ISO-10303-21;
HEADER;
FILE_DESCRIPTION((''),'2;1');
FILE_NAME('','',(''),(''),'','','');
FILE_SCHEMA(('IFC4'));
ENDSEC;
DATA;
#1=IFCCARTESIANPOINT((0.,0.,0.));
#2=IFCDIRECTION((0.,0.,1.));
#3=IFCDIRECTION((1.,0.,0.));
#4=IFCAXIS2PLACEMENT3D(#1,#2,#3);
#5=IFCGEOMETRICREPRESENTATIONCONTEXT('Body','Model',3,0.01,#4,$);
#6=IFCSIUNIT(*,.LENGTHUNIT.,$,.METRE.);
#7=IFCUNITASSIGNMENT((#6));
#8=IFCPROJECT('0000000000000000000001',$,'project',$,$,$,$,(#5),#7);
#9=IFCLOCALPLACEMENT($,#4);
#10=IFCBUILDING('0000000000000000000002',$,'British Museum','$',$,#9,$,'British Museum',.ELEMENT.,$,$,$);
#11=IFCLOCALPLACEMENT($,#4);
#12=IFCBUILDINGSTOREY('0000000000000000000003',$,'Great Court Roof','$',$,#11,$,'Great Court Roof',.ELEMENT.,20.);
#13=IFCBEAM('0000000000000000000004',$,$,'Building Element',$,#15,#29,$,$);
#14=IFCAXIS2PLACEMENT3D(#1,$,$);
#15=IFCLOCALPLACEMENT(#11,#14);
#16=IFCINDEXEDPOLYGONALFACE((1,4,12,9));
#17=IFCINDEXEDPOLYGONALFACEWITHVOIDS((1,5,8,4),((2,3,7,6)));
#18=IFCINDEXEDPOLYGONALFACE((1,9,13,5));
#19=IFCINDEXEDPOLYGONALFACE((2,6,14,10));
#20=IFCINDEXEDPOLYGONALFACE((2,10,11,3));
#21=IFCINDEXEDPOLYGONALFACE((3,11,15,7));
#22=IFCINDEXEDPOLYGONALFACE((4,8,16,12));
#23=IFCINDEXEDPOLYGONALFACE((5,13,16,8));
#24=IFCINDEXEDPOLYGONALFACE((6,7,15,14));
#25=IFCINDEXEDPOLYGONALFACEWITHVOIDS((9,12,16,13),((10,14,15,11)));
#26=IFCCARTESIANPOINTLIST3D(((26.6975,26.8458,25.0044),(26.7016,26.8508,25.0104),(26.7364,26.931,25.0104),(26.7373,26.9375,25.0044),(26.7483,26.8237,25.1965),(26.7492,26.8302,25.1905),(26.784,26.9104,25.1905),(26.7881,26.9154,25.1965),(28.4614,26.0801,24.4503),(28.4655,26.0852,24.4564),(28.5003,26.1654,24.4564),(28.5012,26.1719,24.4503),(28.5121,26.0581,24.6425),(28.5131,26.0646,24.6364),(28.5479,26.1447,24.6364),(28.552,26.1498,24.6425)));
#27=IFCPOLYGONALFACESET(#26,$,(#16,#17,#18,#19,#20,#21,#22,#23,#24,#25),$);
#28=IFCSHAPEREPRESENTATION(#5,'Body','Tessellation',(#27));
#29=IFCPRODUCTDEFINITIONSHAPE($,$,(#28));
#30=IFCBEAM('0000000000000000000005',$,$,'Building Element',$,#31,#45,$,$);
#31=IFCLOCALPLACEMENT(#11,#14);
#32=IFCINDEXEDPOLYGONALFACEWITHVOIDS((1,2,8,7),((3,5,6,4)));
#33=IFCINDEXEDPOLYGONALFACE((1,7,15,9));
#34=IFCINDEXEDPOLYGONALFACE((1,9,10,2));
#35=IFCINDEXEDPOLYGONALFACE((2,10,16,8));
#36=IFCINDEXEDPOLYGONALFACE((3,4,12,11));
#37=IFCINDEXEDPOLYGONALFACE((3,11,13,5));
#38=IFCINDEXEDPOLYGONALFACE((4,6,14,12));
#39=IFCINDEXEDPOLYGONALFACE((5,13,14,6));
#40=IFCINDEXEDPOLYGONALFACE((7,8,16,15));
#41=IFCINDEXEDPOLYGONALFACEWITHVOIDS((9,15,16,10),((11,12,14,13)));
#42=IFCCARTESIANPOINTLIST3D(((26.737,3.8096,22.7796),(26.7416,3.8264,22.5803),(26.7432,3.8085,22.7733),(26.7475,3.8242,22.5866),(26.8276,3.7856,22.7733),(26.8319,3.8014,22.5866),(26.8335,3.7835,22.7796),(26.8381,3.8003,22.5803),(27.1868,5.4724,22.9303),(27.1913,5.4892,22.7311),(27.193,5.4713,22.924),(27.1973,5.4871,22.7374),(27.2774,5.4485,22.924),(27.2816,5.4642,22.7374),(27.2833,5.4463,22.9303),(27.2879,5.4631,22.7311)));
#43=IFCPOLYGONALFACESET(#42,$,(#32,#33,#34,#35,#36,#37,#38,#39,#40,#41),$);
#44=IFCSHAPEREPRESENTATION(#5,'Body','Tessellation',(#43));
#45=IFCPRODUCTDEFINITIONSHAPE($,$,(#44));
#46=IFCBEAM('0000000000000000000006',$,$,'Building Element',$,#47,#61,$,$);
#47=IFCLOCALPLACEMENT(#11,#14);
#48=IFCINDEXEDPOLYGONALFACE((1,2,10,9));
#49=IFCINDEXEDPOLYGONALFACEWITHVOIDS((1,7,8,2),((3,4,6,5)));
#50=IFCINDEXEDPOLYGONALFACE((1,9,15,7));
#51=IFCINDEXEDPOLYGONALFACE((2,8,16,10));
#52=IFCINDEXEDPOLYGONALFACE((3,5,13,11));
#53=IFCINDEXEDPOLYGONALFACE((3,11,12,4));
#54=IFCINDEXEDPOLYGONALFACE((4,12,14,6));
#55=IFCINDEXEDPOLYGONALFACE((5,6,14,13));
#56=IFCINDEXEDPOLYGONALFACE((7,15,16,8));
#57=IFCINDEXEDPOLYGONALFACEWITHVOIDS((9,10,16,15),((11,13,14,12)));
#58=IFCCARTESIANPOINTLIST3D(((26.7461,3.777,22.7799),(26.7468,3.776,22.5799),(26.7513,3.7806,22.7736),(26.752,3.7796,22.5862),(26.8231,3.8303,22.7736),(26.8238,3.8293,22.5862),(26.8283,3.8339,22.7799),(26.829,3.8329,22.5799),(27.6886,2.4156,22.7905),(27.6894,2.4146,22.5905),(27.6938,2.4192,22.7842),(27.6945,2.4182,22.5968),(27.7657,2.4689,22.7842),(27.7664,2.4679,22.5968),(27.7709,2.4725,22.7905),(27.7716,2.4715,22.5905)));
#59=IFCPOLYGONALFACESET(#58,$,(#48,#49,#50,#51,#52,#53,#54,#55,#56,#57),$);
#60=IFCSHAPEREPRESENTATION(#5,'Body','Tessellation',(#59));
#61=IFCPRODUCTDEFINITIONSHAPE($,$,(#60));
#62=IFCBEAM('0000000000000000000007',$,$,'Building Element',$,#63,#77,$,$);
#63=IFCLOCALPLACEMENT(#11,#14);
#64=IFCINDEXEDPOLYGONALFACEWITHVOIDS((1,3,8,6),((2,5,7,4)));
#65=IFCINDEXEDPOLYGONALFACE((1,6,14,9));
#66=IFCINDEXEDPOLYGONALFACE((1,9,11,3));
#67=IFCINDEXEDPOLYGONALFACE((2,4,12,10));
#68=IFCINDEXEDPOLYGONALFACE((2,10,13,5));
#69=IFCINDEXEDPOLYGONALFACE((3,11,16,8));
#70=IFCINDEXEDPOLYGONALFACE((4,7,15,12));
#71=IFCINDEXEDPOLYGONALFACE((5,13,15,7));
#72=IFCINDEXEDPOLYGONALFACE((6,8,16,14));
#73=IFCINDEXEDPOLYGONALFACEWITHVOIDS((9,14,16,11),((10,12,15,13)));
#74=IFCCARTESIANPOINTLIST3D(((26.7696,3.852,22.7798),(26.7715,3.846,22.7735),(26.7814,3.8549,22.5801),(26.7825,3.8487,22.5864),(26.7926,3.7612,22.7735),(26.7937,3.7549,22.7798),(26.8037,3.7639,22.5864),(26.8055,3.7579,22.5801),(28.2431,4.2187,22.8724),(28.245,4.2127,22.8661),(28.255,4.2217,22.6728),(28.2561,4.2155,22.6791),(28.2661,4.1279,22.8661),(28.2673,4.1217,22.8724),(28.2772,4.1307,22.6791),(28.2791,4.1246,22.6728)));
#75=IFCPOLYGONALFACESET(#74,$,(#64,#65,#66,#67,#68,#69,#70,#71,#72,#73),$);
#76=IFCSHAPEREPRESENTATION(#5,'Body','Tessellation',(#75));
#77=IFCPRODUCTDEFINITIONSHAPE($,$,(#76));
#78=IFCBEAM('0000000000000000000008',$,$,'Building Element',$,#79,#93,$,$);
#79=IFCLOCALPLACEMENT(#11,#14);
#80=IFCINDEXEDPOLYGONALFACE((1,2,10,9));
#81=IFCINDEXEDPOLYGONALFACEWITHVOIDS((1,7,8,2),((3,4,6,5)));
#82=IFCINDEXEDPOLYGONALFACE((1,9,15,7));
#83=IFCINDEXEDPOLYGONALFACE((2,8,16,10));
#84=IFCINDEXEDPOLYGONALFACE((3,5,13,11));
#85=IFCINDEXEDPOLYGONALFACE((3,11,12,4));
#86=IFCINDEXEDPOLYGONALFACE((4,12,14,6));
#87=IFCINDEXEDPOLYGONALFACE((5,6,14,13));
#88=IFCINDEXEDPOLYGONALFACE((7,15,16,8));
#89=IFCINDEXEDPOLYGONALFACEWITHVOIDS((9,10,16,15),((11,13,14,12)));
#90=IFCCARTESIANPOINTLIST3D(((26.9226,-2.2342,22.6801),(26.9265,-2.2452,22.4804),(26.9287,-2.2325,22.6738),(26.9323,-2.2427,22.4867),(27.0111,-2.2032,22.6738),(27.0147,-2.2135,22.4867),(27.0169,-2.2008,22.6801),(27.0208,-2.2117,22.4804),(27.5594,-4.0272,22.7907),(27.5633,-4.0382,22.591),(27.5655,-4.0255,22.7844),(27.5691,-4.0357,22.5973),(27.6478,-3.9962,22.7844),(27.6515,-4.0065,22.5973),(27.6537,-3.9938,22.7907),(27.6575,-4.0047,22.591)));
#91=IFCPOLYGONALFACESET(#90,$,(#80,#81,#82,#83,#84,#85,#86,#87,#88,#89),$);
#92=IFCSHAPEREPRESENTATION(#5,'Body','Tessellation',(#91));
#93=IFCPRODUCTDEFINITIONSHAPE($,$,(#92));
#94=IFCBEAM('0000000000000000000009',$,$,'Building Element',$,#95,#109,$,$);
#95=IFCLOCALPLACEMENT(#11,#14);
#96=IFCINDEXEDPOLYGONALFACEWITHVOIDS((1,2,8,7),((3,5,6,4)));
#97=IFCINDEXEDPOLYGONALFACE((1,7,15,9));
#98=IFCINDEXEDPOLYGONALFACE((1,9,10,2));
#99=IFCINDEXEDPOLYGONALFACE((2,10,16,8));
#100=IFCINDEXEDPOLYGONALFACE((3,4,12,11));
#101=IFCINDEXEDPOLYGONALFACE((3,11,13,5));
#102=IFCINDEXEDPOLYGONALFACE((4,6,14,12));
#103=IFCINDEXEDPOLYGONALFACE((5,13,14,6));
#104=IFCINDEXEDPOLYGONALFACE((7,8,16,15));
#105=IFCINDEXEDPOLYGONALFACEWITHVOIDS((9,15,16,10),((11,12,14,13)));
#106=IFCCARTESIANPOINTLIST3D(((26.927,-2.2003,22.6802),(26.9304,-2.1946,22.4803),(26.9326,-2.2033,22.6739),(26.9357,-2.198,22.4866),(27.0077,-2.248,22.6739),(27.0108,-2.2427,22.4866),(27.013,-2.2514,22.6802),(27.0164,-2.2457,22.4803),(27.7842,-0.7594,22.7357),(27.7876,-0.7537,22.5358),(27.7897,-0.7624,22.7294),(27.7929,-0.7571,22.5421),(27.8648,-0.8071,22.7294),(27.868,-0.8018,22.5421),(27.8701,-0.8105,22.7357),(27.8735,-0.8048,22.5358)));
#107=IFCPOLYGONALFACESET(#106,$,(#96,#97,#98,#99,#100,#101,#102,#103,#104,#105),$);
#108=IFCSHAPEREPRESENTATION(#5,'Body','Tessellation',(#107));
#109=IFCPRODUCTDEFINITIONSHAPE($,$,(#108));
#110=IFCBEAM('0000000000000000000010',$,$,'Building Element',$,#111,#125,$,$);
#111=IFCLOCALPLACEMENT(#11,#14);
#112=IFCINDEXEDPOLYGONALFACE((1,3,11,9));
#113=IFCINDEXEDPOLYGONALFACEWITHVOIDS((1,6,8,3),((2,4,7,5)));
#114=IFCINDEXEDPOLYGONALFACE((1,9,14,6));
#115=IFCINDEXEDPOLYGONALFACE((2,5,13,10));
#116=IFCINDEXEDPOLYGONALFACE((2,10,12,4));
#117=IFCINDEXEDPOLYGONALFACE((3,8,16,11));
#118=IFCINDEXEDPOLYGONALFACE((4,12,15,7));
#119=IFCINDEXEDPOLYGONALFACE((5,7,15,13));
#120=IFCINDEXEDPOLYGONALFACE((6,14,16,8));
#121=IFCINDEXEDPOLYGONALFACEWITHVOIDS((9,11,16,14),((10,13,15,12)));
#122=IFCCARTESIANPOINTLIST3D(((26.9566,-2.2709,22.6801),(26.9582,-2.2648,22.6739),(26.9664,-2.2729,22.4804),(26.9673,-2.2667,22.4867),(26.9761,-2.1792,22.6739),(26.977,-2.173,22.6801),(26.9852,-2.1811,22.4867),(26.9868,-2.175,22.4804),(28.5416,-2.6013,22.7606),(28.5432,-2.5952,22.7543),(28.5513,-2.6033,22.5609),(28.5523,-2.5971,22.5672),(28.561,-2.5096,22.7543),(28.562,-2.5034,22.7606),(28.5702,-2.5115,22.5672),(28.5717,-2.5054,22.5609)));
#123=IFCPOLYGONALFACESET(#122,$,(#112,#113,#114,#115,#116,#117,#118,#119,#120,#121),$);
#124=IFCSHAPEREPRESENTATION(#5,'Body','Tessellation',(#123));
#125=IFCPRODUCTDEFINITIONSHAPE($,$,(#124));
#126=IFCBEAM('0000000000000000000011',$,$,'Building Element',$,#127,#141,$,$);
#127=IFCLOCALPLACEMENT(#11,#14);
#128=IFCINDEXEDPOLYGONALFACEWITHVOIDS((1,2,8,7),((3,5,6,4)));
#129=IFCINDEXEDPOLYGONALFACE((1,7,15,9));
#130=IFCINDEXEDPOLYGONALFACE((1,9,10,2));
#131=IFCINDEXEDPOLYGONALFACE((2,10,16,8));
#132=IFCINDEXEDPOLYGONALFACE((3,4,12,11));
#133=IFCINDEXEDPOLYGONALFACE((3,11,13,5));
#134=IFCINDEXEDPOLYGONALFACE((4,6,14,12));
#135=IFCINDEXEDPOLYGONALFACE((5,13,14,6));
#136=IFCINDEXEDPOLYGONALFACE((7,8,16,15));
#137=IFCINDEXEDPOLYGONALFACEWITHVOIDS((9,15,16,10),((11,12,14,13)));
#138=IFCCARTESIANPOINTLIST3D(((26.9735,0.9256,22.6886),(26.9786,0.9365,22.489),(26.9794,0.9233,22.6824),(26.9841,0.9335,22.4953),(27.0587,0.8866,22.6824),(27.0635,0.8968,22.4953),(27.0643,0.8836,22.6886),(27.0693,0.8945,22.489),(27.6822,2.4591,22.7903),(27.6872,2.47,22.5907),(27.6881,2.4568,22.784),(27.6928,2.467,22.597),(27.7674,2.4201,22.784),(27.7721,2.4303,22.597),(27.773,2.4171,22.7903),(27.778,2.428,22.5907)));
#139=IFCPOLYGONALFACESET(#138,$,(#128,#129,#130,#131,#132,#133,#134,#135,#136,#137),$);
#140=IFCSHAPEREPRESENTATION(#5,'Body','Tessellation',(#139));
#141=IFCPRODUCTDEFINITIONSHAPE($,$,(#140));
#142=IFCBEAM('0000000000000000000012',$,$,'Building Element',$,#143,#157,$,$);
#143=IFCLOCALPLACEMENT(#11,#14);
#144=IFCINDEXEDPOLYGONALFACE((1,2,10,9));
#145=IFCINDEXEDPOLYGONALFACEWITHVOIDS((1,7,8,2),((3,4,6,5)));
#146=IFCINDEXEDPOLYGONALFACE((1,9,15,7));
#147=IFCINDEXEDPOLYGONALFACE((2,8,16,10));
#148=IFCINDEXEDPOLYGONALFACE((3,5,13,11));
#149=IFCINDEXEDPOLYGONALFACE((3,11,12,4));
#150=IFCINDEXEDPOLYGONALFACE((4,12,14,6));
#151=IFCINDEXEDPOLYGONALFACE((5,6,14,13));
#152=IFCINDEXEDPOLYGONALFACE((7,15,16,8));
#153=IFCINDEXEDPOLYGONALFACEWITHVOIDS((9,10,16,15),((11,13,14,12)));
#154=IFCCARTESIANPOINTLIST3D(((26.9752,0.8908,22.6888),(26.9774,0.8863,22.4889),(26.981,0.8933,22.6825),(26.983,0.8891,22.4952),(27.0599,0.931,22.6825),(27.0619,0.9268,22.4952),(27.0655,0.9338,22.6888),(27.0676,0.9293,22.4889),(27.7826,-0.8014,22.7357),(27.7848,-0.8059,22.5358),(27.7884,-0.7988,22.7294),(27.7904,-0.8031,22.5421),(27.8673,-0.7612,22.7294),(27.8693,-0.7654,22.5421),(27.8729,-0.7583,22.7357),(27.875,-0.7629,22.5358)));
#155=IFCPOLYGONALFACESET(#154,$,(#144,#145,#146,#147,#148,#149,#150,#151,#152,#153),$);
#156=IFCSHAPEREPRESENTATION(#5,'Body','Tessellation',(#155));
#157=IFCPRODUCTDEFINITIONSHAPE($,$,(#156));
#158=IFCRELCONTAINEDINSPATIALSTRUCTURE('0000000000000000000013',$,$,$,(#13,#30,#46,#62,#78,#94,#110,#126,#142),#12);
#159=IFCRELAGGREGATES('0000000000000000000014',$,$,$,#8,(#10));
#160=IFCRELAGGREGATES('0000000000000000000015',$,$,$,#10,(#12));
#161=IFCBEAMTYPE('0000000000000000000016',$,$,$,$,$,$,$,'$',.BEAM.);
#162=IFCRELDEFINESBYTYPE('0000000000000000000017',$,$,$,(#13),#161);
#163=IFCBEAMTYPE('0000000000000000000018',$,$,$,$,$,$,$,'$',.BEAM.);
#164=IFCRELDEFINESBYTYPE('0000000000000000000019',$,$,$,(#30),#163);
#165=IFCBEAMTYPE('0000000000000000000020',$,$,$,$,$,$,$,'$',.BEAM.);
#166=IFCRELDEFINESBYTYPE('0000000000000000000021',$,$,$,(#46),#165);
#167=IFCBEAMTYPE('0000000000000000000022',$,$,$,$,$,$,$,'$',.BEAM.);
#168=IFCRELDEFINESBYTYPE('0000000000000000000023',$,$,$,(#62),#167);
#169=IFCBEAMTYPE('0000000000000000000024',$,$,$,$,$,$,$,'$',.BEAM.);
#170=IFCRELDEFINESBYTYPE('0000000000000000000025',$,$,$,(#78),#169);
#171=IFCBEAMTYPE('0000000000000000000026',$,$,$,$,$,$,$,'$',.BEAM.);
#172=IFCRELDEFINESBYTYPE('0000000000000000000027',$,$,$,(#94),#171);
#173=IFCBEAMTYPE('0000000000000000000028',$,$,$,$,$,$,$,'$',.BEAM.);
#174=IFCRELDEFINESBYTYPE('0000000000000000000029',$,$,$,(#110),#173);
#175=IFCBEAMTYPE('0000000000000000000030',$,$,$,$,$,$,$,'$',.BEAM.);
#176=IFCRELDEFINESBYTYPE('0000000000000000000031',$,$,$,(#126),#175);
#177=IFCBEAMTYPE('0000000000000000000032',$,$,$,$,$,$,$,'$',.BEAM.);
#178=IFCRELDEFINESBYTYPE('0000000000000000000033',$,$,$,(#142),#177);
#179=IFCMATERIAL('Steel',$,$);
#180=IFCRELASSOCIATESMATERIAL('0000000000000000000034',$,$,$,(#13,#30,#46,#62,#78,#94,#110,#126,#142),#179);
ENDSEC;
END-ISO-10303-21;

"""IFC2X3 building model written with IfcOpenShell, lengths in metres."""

from ifc_helpers import new_model, si_unit, frame, origin_with_axes, origin_2d, place, context, project, spatial, hollow_rectangle, extrude, material, type_object, element, save


model = new_model("IFC2X3")

# Units and contexts
model_context = context("Model", 3, precision=0.01, world=origin_with_axes(), identifier="Body")
ifc_project = project(units=[si_unit("LENGTHUNIT", "METRE")], contexts=[model_context])

# Building, storey
building_placement = place(None, origin_with_axes())
building = spatial("IfcBuilding", under=ifc_project, at=building_placement, Name="British Museum", Description="$", LongName="British Museum", CompositionType="ELEMENT")
storey_placement = place(None, origin_with_axes())
storey = spatial("IfcBuildingStorey", under=building, at=storey_placement, Name="Great Court Roof", Description="$", LongName="Great Court Roof", CompositionType="ELEMENT", Elevation=20.0)

# Beams
ifc_material = material(Name="Steel")
beam_type_1 = type_object("IfcBeamType", ElementType="$", PredefinedType="BEAM")
beam_1_placement = place(None, origin_with_axes())
element("IfcBeam", 1, at=beam_1_placement, inside=storey, type_object=beam_type_1, material=ifc_material, Description="Building Element", context=model_context, shape_type="SweptSolid", body=[
    extrude(hollow_rectangle(XDim=0.1, YDim=0.2, WallThickness=0.0063, InnerFilletRadius=0.0, OuterFilletRadius=0.0, at=origin_2d()), frame((26.7428, 26.8806, 25.1005), z_axis=(0.881448, -0.382608, -0.276877), x_axis=(0.398175, 0.91731, 0.0)), (0.0, 0.0, 1.0), 2.0011),
])
beam_type_2 = type_object("IfcBeamType", ElementType="$", PredefinedType="BEAM")
beam_2_placement = place(None, origin_with_axes())
element("IfcBeam", 2, at=beam_2_placement, inside=storey, type_object=beam_type_2, material=ifc_material, Description="Building Element", context=model_context, shape_type="SweptSolid", body=[
    extrude(hollow_rectangle(XDim=0.1, YDim=0.2, WallThickness=0.0063, InnerFilletRadius=0.0, OuterFilletRadius=0.0, at=origin_2d()), frame((26.7876, 3.8049, 22.6799), z_axis=(0.260104, 0.961637, 0.087183), x_axis=(-0.965312, 0.261098, 0.0)), (0.0, 0.0, 1.0), 1.7292),
])
beam_type_3 = type_object("IfcBeamType", ElementType="$", PredefinedType="BEAM")
beam_3_placement = place(None, origin_with_axes())
element("IfcBeam", 3, at=beam_3_placement, inside=storey, type_object=beam_type_3, material=ifc_material, Description="Building Element", context=model_context, shape_type="SweptSolid", body=[
    extrude(hollow_rectangle(XDim=0.1, YDim=0.2, WallThickness=0.0063, InnerFilletRadius=0.0, OuterFilletRadius=0.0, at=origin_2d()), frame((26.7876, 3.8049, 22.6799), z_axis=(0.569218, -0.822162, 0.006369), x_axis=(0.822178, 0.56923, 0.0)), (0.0, 0.0, 1.0), 1.6559),
])
beam_type_4 = type_object("IfcBeamType", ElementType="$", PredefinedType="BEAM")
beam_4_placement = place(None, origin_with_axes())
element("IfcBeam", 4, at=beam_4_placement, inside=storey, type_object=beam_type_4, material=ifc_material, Description="Building Element", context=model_context, shape_type="SweptSolid", body=[
    extrude(hollow_rectangle(XDim=0.1, YDim=0.2, WallThickness=0.0063, InnerFilletRadius=0.0, OuterFilletRadius=0.0, at=origin_2d()), frame((26.7876, 3.8049, 22.6799), z_axis=(0.968596, 0.241063, 0.060918), x_axis=(-0.241512, 0.970398, 0.0)), (0.0, 0.0, 1.0), 1.5213),
])
beam_type_5 = type_object("IfcBeamType", ElementType="$", PredefinedType="BEAM")
beam_5_placement = place(None, origin_with_axes())
element("IfcBeam", 5, at=beam_5_placement, inside=storey, type_object=beam_type_5, material=ifc_material, Description="Building Element", context=model_context, shape_type="SweptSolid", body=[
    extrude(hollow_rectangle(XDim=0.1, YDim=0.2, WallThickness=0.0063, InnerFilletRadius=0.0, OuterFilletRadius=0.0, at=origin_2d()), frame((26.9717, -2.223, 22.5803), z_axis=(0.334108, -0.940747, 0.058033), x_axis=(0.942335, 0.334672, 0.0)), (0.0, 0.0, 1.0), 1.9059),
])
beam_type_6 = type_object("IfcBeamType", ElementType="$", PredefinedType="BEAM")
beam_6_placement = place(None, origin_with_axes())
element("IfcBeam", 6, at=beam_6_placement, inside=storey, type_object=beam_type_6, material=ifc_material, Description="Building Element", context=model_context, shape_type="SweptSolid", body=[
    extrude(hollow_rectangle(XDim=0.1, YDim=0.2, WallThickness=0.0063, InnerFilletRadius=0.0, OuterFilletRadius=0.0, at=origin_2d()), frame((26.9717, -2.223, 22.5803), z_axis=(0.510977, 0.858958, 0.033064), x_axis=(-0.859428, 0.511257, 0.0)), (0.0, 0.0, 1.0), 1.6774),
])
beam_type_7 = type_object("IfcBeamType", ElementType="$", PredefinedType="BEAM")
beam_7_placement = place(None, origin_with_axes())
element("IfcBeam", 7, at=beam_7_placement, inside=storey, type_object=beam_type_7, material=ifc_material, Description="Building Element", context=model_context, shape_type="SweptSolid", body=[
    extrude(hollow_rectangle(XDim=0.1, YDim=0.2, WallThickness=0.0063, InnerFilletRadius=0.0, OuterFilletRadius=0.0, at=origin_2d()), frame((26.9717, -2.223, 22.5803), z_axis=(0.977752, -0.203803, 0.049648), x_axis=(0.204054, 0.97896, 0.0)), (0.0, 0.0, 1.0), 1.621),
])
beam_type_8 = type_object("IfcBeamType", ElementType="$", PredefinedType="BEAM")
beam_8_placement = place(None, origin_with_axes())
element("IfcBeam", 8, at=beam_8_placement, inside=storey, type_object=beam_type_8, material=ifc_material, Description="Building Element", context=model_context, shape_type="SweptSolid", body=[
    extrude(hollow_rectangle(XDim=0.1, YDim=0.2, WallThickness=0.0063, InnerFilletRadius=0.0, OuterFilletRadius=0.0, at=origin_2d()), frame((27.0214, 0.9101, 22.5888), z_axis=(0.418739, 0.906117, 0.060072), x_axis=(-0.907757, 0.419497, 0.0)), (0.0, 0.0, 1.0), 1.6924),
])
beam_type_9 = type_object("IfcBeamType", ElementType="$", PredefinedType="BEAM")
beam_9_placement = place(None, origin_with_axes())
element("IfcBeam", 9, at=beam_9_placement, inside=storey, type_object=beam_type_9, material=ifc_material, Description="Building Element", context=model_context, shape_type="SweptSolid", body=[
    extrude(hollow_rectangle(XDim=0.1, YDim=0.2, WallThickness=0.0063, InnerFilletRadius=0.0, OuterFilletRadius=0.0, at=origin_2d()), frame((27.0214, 0.9101, 22.5888), z_axis=(0.430492, -0.902248, 0.025012), x_axis=(0.90253, 0.430627, 0.0)), (0.0, 0.0, 1.0), 1.8755),
])

save(model, "model.ifc")
